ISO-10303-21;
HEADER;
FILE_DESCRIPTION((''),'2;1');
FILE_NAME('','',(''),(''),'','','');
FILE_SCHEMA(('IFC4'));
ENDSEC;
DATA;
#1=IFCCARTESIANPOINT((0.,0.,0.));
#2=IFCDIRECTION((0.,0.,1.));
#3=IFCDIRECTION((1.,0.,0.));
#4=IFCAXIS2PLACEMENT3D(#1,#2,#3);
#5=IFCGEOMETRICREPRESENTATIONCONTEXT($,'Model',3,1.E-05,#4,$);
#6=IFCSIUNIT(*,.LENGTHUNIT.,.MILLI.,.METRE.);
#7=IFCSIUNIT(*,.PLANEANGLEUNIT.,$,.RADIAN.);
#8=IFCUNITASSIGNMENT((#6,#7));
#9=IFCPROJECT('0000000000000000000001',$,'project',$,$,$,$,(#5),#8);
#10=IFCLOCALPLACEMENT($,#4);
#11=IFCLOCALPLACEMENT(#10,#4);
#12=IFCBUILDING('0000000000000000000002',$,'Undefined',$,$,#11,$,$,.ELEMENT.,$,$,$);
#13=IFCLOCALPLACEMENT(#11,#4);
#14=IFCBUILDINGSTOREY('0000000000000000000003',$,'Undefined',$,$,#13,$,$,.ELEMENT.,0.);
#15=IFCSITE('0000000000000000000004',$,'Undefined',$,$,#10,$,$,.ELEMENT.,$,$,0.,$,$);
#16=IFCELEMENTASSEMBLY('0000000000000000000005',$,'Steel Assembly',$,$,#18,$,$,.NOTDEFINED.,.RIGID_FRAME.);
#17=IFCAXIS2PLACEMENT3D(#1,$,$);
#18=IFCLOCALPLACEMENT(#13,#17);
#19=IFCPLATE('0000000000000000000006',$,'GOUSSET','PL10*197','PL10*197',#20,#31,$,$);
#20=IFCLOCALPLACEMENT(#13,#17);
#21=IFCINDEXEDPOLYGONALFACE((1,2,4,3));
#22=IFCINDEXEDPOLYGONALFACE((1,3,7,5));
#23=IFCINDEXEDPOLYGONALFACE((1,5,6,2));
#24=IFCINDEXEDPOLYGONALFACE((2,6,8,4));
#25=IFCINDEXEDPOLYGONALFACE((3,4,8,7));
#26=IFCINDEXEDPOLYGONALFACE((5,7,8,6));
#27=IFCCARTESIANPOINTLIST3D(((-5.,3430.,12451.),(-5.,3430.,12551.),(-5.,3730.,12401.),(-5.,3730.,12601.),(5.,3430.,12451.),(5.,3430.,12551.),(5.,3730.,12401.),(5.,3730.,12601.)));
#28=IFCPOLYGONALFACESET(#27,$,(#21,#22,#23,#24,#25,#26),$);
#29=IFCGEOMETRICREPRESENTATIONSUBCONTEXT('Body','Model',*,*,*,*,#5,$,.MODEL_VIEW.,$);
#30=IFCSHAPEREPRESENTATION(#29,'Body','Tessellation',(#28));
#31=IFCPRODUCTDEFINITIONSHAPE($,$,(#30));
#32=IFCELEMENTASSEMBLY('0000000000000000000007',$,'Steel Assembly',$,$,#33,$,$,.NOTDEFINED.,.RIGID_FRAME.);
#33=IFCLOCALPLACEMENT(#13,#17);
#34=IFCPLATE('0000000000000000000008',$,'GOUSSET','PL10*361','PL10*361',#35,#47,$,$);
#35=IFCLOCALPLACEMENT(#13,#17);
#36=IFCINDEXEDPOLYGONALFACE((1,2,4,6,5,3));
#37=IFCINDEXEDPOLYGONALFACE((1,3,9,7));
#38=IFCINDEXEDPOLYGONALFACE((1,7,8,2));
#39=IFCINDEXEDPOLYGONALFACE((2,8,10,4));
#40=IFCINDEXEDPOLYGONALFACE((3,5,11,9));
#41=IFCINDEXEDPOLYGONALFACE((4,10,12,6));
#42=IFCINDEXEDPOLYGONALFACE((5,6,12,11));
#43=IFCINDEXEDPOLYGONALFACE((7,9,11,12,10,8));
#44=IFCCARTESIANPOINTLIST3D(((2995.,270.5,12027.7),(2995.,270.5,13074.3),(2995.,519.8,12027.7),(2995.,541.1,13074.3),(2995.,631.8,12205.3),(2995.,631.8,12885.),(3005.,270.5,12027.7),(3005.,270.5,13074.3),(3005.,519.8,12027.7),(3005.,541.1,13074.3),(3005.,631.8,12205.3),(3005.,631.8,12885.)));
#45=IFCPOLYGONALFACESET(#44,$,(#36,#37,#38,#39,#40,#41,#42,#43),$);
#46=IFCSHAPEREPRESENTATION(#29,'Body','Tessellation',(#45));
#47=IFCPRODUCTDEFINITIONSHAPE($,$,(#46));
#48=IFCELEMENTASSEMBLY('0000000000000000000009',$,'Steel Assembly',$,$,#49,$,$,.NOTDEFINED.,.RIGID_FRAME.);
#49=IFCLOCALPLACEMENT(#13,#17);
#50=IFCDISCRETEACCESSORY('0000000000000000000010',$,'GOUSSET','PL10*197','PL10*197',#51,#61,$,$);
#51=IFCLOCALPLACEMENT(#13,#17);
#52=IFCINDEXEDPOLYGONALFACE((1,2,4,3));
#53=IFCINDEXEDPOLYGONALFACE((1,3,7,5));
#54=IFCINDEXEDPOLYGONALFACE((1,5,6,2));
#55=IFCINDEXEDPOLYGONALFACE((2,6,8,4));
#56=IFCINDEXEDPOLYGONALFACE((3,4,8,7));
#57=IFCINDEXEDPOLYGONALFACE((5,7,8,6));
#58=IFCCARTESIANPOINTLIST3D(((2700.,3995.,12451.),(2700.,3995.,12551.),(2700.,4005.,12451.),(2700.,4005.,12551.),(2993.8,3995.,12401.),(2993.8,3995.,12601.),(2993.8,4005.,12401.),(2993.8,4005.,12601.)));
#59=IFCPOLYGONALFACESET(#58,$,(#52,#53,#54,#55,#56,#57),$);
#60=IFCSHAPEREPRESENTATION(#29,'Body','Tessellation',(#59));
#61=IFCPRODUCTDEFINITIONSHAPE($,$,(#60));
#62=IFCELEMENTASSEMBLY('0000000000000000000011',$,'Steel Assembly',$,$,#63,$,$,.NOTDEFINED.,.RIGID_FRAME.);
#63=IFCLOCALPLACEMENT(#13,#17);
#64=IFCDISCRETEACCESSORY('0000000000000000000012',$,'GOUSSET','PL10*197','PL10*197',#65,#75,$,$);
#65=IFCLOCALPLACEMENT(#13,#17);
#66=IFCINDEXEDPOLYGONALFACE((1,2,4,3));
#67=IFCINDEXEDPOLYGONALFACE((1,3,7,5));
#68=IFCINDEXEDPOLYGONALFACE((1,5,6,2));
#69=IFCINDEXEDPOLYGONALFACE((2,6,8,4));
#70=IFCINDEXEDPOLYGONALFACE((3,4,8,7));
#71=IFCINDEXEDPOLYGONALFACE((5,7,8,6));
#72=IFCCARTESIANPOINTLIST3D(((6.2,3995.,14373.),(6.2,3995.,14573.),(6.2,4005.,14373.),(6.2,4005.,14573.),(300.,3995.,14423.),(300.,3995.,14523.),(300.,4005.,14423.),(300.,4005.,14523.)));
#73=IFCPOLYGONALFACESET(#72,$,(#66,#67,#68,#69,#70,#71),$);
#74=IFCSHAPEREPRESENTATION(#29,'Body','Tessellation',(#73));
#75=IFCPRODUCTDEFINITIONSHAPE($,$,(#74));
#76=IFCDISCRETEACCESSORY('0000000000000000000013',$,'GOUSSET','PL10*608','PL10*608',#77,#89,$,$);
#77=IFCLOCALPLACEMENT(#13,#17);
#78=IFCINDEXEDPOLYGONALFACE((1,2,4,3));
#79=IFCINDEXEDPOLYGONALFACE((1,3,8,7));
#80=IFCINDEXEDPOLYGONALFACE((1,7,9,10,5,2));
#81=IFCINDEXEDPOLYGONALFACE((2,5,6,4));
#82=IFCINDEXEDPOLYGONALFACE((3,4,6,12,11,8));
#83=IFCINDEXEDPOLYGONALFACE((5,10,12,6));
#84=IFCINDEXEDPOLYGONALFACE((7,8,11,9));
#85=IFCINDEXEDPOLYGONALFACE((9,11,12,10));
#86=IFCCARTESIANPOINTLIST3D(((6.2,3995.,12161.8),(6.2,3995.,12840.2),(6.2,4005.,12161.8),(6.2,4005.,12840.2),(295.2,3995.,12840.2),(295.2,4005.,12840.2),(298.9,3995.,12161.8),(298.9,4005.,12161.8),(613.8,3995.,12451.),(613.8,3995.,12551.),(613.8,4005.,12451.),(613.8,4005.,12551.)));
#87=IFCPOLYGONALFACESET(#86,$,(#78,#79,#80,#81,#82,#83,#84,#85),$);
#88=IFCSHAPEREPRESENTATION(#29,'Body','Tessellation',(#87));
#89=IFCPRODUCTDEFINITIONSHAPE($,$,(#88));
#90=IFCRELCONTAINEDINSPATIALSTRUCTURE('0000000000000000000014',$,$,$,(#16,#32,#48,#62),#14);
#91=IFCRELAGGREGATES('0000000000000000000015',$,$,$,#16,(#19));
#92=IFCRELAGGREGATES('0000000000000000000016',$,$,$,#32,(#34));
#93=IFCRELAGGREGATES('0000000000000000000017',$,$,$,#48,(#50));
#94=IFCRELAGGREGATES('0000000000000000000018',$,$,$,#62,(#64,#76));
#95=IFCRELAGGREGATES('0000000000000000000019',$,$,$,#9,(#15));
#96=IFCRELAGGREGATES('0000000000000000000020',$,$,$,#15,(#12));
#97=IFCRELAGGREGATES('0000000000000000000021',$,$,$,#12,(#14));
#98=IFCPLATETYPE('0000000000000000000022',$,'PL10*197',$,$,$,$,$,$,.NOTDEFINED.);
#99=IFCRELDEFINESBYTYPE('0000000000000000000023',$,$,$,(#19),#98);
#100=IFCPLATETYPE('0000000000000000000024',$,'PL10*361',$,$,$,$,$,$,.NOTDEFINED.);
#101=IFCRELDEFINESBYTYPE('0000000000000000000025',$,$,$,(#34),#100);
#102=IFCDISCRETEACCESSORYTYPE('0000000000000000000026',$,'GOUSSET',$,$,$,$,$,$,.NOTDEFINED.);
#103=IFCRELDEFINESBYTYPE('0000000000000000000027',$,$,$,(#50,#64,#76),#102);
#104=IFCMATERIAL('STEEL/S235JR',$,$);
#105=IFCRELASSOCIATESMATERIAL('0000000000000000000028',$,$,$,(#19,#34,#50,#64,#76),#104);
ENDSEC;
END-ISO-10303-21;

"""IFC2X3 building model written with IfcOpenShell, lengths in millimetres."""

from ifc_helpers import new_model, si_unit, frame, origin_with_axes, place, context, subcontext, project, spatial, polyline, outline, extrude, material, type_object, element, aggregate, save


model = new_model("IFC2X3")

# Units and contexts
model_context = context("Model", 3, precision=1e-05, world=origin_with_axes())
body_context = subcontext(model_context, "Body", "Model", "MODEL_VIEW")
ifc_project = project(units=[si_unit("LENGTHUNIT", "METRE", prefix="MILLI"), si_unit("PLANEANGLEUNIT", "RADIAN")], contexts=[model_context])

# Site, building, storey
site_placement = place(None, origin_with_axes())
site = spatial("IfcSite", under=ifc_project, at=site_placement, Name="Undefined", CompositionType="ELEMENT", RefElevation=0.0)
building_placement = place(site_placement, origin_with_axes())
building = spatial("IfcBuilding", under=site, at=building_placement, Name="Undefined", CompositionType="ELEMENT")
storey_placement = place(building_placement, origin_with_axes())
storey = spatial("IfcBuildingStorey", under=building, at=storey_placement, Name="Undefined", CompositionType="ELEMENT", Elevation=0.0)

# Shared definitions
ifc_material_1 = material(Name="STEEL/S235JR")

# Element assemblies, plates
plate_type_1 = type_object("IfcPlateType", Name="PL10*197", PredefinedType="NOTDEFINED")
assembly_1_placement = place(storey_placement, origin_with_axes())
assembly_1 = element("IfcElementAssembly", 1, at=assembly_1_placement, inside=storey, Name="Steel Assembly", AssemblyPlace="NOTDEFINED", PredefinedType="RIGID_FRAME")
plate_1_placement = place(assembly_1_placement, frame((0.0, 3730.0, 12601.0), z_axis=(-1.0, 0.0, 0.0), x_axis=(0.0, 0.0, -1.0)))
plate_1 = element("IfcPlate", 2, at=plate_1_placement, type_object=plate_type_1, material=ifc_material_1, Name="GOUSSET", Description="PL10*197", ObjectType="PL10*197", context=body_context, shape_type="SweptSolid", body=[
    extrude(outline(polyline([(0.0, 0.0), (200.0, 0.0), (150.0, 300.0), (50.0, 300.0), (0.0, 0.0)])), frame((0.0, 0.0, -5.0), z_axis=(0.0, 0.0, 1.0), x_axis=(1.0, 0.0, 0.0)), (0.0, 0.0, 1.0), 10.0),
])
aggregate(assembly_1, [plate_1])
assembly_2_placement = place(storey_placement, origin_with_axes())
assembly_2 = element("IfcElementAssembly", 3, at=assembly_2_placement, inside=storey, Name="Steel Assembly", AssemblyPlace="NOTDEFINED", PredefinedType="RIGID_FRAME")
plate_type_2 = type_object("IfcPlateType", Name="PL10*361", PredefinedType="NOTDEFINED")
plate_2_placement = place(assembly_2_placement, frame((3000.0, 541.1, 13074.3), z_axis=(1.0, 0.0, 0.0), x_axis=(0.0, -1.0, 0.0)))
plate_2 = element("IfcPlate", 4, at=plate_2_placement, type_object=plate_type_2, material=ifc_material_1, Name="GOUSSET", Description="PL10*361", ObjectType="PL10*361", context=body_context, shape_type="SweptSolid", body=[
    extrude(outline(polyline([(0.0, 0.0), (270.5, 0.0), (270.5, 1046.7), (21.3, 1046.7), (-90.7, 869.1), (-90.7, 189.4), (0.0, 0.0)])), frame((0.0, 0.0, -5.0), z_axis=(0.0, 0.0, 1.0), x_axis=(1.0, 0.0, 0.0)), (0.0, 0.0, 1.0), 10.0),
])
aggregate(assembly_2, [plate_2])

# Element assembly, discrete accessory
assembly_3_placement = place(storey_placement, origin_with_axes())
assembly_3 = element("IfcElementAssembly", 5, at=assembly_3_placement, inside=storey, Name="Steel Assembly", AssemblyPlace="NOTDEFINED", PredefinedType="RIGID_FRAME")
discrete_accessory_type_1 = type_object("IfcDiscreteAccessoryType", Name="GOUSSET")
discrete_accessory_1_placement = place(assembly_3_placement, frame((2993.8, 4000.0, 12601.0), z_axis=(0.0, 1.0, 0.0), x_axis=(0.0, 0.0, -1.0)))
discrete_accessory_1 = element("IfcDiscreteAccessory", 6, at=discrete_accessory_1_placement, type_object=discrete_accessory_type_1, material=ifc_material_1, Name="GOUSSET", Description="PL10*197", ObjectType="PL10*197", context=body_context, shape_type="SweptSolid", body=[
    extrude(outline(polyline([(0.0, 0.0), (200.0, 0.0), (150.0, 293.8), (50.0, 293.8), (0.0, 0.0)])), frame((0.0, 0.0, -5.0), z_axis=(0.0, 0.0, 1.0), x_axis=(1.0, 0.0, 0.0)), (0.0, 0.0, 1.0), 10.0),
])
aggregate(assembly_3, [discrete_accessory_1])

# Element assembly, discrete accessories
assembly_4_placement = place(storey_placement, origin_with_axes())
assembly_4 = element("IfcElementAssembly", 7, at=assembly_4_placement, inside=storey, Name="Steel Assembly", AssemblyPlace="NOTDEFINED", PredefinedType="RIGID_FRAME")
discrete_accessory_2_placement = place(assembly_4_placement, frame((6.2, 4000.0, 14573.0), z_axis=(0.0, -1.0, 0.0), x_axis=(0.0, 0.0, -1.0)))
discrete_accessory_2 = element("IfcDiscreteAccessory", 8, at=discrete_accessory_2_placement, type_object=discrete_accessory_type_1, material=ifc_material_1, Name="GOUSSET", Description="PL10*197", ObjectType="PL10*197", context=body_context, shape_type="SweptSolid", body=[
    extrude(outline(polyline([(0.0, 0.0), (200.0, 0.0), (150.0, 293.8), (50.0, 293.8), (0.0, 0.0)])), frame((0.0, 0.0, -5.0), z_axis=(0.0, 0.0, 1.0), x_axis=(1.0, 0.0, 0.0)), (0.0, 0.0, 1.0), 10.0),
])
discrete_accessory_3_placement = place(assembly_4_placement, frame((6.2, 4000.0, 12840.2), z_axis=(0.0, 1.0, 0.0), x_axis=(1.0, 0.0, 0.0)))
discrete_accessory_3 = element("IfcDiscreteAccessory", 9, at=discrete_accessory_3_placement, type_object=discrete_accessory_type_1, material=ifc_material_1, Name="GOUSSET", Description="PL10*608", ObjectType="PL10*608", context=body_context, shape_type="SweptSolid", body=[
    extrude(outline(polyline([(0.0, 0.0), (288.9, 0.0), (607.5, 289.2), (607.5, 389.2), (292.6, 678.5), (0.0, 678.5), (0.0, 0.0)])), frame((0.0, 0.0, -5.0), z_axis=(0.0, 0.0, 1.0), x_axis=(1.0, 0.0, 0.0)), (0.0, 0.0, 1.0), 10.0),
])
aggregate(assembly_4, [discrete_accessory_2, discrete_accessory_3])

save(model, "model.ifc")
